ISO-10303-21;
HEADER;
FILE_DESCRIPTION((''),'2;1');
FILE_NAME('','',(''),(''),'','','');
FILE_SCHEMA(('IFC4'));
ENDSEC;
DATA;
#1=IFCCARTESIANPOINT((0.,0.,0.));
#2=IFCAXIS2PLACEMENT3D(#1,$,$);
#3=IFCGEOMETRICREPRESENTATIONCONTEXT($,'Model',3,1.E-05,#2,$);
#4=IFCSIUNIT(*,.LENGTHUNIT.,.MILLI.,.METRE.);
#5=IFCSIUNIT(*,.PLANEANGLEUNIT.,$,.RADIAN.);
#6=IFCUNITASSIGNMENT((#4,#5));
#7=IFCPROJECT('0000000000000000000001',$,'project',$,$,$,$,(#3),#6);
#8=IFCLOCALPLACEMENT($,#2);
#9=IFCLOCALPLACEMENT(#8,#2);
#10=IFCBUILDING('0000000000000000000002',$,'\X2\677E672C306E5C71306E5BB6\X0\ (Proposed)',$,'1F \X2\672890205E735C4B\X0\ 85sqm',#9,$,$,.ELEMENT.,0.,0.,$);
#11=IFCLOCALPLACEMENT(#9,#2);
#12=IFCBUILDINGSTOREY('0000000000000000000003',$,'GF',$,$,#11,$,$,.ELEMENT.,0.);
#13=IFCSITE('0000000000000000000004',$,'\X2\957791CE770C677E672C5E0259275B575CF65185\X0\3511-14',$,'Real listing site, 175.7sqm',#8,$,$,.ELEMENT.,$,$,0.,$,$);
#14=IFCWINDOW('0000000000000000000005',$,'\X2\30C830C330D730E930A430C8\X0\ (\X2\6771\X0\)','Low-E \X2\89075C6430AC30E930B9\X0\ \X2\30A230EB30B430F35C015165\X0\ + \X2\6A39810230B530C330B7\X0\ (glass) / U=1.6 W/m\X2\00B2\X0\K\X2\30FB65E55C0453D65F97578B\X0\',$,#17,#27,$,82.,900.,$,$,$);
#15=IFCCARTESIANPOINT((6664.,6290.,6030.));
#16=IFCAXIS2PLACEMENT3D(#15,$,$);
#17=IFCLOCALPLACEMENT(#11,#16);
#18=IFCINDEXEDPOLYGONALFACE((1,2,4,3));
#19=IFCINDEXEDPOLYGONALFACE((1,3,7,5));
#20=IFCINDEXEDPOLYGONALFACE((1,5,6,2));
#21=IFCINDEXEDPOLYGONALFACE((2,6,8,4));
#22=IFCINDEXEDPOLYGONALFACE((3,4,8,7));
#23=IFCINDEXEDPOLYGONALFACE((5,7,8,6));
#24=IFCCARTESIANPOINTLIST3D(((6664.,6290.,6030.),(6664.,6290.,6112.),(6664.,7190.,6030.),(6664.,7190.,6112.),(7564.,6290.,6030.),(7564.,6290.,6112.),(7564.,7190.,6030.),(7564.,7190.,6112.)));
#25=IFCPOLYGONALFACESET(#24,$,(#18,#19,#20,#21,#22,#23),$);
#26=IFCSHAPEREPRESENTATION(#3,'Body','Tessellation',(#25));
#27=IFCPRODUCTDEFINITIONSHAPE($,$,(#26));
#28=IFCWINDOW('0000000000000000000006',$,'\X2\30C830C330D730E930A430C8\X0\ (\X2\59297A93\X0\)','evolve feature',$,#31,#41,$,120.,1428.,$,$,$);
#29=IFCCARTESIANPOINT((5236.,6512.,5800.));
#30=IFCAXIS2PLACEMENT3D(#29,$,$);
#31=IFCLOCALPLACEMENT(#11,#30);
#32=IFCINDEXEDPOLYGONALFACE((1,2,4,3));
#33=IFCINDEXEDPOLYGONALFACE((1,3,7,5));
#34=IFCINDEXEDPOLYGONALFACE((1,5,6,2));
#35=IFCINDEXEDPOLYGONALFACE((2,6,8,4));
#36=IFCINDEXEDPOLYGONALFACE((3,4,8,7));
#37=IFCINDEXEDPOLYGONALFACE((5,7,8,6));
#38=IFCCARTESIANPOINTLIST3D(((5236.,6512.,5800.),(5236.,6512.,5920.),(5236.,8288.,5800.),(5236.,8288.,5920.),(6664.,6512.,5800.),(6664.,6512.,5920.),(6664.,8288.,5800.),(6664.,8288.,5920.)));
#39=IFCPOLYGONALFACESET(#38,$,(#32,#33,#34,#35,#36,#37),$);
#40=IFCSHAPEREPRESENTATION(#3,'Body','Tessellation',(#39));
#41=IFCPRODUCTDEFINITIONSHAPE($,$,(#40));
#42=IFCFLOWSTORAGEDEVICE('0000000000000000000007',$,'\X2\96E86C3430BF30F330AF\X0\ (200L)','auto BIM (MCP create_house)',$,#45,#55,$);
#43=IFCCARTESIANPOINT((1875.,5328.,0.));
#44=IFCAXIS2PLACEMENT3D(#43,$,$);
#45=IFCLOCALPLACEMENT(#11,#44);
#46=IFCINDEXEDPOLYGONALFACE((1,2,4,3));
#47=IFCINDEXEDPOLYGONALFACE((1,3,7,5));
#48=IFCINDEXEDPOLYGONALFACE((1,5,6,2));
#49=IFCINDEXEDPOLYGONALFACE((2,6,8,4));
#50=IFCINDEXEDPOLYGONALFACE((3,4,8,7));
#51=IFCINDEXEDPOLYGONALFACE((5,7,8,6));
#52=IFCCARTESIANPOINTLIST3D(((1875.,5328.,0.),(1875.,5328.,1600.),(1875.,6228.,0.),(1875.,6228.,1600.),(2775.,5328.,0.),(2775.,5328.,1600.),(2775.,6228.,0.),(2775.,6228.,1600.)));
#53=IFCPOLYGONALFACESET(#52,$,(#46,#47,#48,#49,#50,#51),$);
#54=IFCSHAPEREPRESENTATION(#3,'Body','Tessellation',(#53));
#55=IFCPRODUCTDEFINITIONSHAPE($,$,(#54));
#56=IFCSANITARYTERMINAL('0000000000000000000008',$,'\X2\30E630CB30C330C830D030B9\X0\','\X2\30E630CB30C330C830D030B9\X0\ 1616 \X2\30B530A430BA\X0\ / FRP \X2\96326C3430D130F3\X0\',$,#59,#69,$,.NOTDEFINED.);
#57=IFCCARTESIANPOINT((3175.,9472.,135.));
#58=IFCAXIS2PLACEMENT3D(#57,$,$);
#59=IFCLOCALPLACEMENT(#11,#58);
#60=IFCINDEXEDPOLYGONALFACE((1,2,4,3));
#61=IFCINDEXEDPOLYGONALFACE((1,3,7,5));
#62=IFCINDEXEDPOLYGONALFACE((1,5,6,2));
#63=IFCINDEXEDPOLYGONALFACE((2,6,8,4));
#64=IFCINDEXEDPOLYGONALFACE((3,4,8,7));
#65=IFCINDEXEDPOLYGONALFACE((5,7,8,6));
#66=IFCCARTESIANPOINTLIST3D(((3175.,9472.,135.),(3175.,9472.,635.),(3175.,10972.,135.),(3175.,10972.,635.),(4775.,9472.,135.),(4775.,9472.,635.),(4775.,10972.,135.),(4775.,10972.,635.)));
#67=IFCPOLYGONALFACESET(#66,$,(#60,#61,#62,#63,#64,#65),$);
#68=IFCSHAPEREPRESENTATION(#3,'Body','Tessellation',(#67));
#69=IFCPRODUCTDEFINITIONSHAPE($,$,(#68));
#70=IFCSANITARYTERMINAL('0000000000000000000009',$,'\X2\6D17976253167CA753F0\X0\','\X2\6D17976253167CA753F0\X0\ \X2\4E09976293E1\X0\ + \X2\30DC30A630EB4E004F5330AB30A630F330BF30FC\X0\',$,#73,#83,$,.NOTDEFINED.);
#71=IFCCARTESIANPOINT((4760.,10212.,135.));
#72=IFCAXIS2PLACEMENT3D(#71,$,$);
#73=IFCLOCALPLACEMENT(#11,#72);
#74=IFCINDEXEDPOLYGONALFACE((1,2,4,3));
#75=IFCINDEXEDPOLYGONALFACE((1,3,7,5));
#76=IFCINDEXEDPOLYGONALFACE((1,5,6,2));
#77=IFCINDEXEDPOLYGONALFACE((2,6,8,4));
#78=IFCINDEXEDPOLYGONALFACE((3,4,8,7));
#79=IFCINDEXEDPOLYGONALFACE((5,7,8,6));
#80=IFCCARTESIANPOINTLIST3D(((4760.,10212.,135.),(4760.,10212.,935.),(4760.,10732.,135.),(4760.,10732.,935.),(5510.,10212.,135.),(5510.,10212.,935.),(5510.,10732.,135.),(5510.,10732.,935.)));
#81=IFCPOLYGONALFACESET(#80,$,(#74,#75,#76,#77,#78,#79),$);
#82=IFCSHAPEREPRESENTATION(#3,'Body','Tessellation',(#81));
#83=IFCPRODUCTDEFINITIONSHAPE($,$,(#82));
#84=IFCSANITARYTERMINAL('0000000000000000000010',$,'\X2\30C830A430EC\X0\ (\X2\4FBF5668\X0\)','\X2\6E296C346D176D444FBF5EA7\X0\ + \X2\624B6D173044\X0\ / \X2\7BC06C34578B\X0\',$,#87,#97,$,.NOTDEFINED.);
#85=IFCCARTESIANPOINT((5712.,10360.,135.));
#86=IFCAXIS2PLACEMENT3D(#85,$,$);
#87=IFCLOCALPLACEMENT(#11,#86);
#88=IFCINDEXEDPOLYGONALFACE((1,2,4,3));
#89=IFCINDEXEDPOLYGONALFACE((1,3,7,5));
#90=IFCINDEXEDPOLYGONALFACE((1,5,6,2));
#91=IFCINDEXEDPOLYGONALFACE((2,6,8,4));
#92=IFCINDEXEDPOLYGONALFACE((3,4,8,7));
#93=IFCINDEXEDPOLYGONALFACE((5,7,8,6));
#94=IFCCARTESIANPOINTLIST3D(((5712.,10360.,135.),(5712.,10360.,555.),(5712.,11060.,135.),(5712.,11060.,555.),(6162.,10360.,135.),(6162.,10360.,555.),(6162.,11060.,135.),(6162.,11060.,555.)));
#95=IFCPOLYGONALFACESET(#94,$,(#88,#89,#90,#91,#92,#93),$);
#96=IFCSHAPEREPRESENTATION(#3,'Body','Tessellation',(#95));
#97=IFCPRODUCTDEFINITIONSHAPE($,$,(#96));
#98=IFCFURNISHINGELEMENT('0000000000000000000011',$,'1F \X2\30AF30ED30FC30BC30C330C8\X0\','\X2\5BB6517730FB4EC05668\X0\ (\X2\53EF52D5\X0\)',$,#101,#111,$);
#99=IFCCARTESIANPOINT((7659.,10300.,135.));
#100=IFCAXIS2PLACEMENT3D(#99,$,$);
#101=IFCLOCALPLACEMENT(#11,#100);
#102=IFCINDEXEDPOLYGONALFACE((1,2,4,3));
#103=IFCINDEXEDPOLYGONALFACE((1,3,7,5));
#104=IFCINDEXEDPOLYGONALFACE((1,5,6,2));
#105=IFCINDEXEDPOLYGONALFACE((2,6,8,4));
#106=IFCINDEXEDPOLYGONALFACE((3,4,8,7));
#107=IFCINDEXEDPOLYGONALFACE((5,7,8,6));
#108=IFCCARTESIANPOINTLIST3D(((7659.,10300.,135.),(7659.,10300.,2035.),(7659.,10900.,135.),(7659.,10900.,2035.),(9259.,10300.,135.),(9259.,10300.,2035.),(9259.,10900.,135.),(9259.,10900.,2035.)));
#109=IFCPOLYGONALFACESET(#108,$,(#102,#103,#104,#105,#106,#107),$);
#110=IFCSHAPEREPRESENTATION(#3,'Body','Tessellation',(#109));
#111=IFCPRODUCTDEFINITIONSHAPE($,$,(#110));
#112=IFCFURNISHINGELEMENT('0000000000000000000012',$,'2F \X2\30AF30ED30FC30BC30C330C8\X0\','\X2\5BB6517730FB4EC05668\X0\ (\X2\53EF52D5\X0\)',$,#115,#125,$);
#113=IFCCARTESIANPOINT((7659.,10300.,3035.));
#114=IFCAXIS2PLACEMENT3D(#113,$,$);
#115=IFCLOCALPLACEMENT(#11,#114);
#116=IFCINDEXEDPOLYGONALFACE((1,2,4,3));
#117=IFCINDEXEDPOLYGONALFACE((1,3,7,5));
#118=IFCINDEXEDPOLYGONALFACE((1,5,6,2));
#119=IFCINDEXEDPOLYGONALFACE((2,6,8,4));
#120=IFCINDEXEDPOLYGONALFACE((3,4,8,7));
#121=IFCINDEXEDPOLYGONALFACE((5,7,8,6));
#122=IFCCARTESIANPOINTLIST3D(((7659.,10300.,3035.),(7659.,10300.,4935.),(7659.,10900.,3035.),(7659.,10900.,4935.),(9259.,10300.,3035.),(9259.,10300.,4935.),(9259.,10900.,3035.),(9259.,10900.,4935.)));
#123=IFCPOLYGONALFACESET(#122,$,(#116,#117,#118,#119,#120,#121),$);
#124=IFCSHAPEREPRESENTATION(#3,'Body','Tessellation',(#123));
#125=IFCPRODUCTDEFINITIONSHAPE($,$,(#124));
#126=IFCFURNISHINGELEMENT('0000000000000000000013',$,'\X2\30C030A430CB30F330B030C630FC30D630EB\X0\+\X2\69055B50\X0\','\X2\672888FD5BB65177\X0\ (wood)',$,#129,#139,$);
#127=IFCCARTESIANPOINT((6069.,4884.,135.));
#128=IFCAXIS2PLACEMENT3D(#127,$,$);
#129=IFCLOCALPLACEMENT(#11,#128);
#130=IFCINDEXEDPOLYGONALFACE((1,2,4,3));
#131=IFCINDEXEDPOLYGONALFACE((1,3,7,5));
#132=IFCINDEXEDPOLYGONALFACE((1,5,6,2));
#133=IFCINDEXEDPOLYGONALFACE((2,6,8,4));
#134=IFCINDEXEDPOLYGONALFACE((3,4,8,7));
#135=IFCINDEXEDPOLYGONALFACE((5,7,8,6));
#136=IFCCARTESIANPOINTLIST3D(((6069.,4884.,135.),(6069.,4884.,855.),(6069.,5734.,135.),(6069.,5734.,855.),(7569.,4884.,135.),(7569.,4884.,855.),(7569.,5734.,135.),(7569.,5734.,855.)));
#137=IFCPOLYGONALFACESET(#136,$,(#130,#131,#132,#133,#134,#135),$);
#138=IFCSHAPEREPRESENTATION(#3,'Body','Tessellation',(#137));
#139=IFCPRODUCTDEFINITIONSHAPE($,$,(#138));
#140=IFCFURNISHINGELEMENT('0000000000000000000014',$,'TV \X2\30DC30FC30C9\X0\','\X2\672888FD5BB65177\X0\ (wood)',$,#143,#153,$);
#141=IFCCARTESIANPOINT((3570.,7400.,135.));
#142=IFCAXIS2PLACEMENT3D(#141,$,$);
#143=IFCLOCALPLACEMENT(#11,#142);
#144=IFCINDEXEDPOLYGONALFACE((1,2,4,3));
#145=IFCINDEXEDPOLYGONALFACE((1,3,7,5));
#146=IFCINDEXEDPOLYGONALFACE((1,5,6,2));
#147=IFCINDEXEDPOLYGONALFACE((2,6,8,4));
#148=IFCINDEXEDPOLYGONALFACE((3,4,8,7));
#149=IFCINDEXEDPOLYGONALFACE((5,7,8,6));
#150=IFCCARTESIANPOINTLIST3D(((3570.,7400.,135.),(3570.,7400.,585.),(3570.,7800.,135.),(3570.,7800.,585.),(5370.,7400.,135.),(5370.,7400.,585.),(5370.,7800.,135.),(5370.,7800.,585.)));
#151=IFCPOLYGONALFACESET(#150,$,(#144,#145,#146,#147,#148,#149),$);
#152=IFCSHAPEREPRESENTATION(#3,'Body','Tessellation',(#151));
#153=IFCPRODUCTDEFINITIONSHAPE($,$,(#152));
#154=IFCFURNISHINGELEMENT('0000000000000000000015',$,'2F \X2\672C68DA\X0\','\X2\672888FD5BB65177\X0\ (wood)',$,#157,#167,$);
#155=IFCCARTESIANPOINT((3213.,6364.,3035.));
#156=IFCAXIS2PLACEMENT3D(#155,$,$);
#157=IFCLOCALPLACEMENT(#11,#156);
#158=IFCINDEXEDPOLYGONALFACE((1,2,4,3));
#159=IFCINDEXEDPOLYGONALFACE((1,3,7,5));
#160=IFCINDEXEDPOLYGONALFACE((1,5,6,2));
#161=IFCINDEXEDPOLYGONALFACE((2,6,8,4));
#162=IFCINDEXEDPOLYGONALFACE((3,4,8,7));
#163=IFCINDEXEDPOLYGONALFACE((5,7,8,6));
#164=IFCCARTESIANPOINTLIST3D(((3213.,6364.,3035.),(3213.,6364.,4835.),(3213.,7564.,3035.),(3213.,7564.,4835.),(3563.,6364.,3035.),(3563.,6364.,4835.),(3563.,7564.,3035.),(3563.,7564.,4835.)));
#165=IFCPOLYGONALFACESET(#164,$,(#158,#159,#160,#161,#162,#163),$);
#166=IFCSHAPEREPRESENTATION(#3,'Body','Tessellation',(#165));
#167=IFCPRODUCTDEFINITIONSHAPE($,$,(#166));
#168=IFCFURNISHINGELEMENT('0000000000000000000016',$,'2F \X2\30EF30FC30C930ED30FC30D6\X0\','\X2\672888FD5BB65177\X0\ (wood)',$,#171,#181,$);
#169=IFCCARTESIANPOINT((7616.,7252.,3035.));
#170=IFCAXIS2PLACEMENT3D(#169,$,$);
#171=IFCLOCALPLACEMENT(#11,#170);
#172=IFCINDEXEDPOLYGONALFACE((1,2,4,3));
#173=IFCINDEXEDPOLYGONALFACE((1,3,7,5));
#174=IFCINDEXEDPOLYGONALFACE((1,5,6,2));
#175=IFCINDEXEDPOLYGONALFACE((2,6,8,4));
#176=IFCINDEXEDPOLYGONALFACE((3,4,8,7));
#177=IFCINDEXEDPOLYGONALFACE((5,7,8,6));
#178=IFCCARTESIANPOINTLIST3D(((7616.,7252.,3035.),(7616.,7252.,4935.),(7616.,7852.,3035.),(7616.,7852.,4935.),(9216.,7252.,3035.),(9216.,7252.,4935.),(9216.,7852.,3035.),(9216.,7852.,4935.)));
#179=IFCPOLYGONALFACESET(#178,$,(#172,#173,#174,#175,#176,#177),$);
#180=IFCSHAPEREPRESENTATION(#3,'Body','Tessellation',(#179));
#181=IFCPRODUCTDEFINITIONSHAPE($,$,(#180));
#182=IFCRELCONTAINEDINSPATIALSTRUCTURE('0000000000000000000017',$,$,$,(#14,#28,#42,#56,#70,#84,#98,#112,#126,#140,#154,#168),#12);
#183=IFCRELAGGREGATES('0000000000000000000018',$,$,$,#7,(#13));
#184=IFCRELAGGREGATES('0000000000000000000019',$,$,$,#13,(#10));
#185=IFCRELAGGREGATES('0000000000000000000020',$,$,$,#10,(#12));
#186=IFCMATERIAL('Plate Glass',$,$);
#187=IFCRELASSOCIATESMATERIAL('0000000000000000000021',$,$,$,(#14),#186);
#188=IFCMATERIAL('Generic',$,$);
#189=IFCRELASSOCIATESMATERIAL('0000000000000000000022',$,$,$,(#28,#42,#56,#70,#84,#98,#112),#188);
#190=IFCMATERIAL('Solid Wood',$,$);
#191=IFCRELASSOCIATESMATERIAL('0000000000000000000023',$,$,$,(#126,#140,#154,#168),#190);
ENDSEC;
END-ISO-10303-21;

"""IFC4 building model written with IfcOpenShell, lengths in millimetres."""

from ifc_helpers import new_model, si_unit, frame, frame_2d, origin, place, context, project, spatial, rectangle, extrude, material, element, save


model = new_model("IFC4")

# Units and contexts
model_context = context("Model", 3, precision=1e-05, world=origin())
ifc_project = project(units=[si_unit("LENGTHUNIT", "METRE", prefix="MILLI"), si_unit("PLANEANGLEUNIT", "RADIAN")], contexts=[model_context])

# Site, building, storey
site_placement = place(None, origin())
site = spatial("IfcSite", under=ifc_project, at=site_placement, Name="長野県松本市大字島内3511-14", ObjectType="Real listing site, 175.7sqm", CompositionType="ELEMENT", RefElevation=0.0)
building_placement = place(site_placement, origin())
building = spatial("IfcBuilding", under=site, at=building_placement, Name="松本の山の家 (Proposed)", ObjectType="1F 木造平屋 85sqm", CompositionType="ELEMENT", ElevationOfRefHeight=0.0, ElevationOfTerrain=0.0)
storey_placement = place(building_placement, origin())
storey = spatial("IfcBuildingStorey", under=building, at=storey_placement, Name="GF", CompositionType="ELEMENT", Elevation=0.0)

# Shared definitions
ifc_material_1 = material(Name="Solid Wood")
ifc_material_2 = material(Name="Plate Glass")

# Windows
window_1_placement = place(storey_placement, frame((6664.0, 6290.0, 6030.0)))
element("IfcWindow", 1, at=window_1_placement, inside=storey, material=ifc_material_2, Name="トップライト (東)", Description="Low-E 複層ガラス アルゴン封入 + 樹脂サッシ (glass) / U=1.6 W/m²K・日射取得型", OverallHeight=82.0, OverallWidth=900.0, context=model_context, shape_type="SweptSolid", body=[
    extrude(rectangle(XDim=900.0, YDim=900.0, at=frame_2d((450.0, 450.0))), frame((6664.0, 6290.0, 6030.0)), (0.0, 0.0, 1.0), 82.0),
])
ifc_material_3 = material(Name="Generic")
window_2_placement = place(storey_placement, frame((5236.0, 6512.0, 5800.0)))
element("IfcWindow", 2, at=window_2_placement, inside=storey, material=ifc_material_3, Name="トップライト (天窓)", Description="evolve feature", OverallHeight=120.0, OverallWidth=1428.0, context=model_context, shape_type="SweptSolid", body=[
    extrude(rectangle(XDim=1428.0, YDim=1776.0, at=frame_2d((714.0, 888.0))), frame((5236.0, 6512.0, 5800.0)), (0.0, 0.0, 1.0), 120.0),
])

# Flow storage device
flow_storage_device_placement = place(storey_placement, frame((1875.0, 5328.0, 0.0)))
element("IfcFlowStorageDevice", 3, at=flow_storage_device_placement, inside=storey, material=ifc_material_3, Name="雨水タンク (200L)", Description="auto BIM (MCP create_house)", context=model_context, shape_type="SweptSolid", body=[
    extrude(rectangle(XDim=900.0, YDim=900.0, at=frame_2d((450.0, 450.0))), frame((1875.0, 5328.0, 0.0)), (0.0, 0.0, 1.0), 1600.0),
])

# Sanitary terminals
sanitary_terminal_1_placement = place(storey_placement, frame((3175.0, 9472.0, 135.0)))
element("IfcSanitaryTerminal", 4, at=sanitary_terminal_1_placement, inside=storey, material=ifc_material_3, Name="ユニットバス", Description="ユニットバス 1616 サイズ / FRP 防水パン", PredefinedType="NOTDEFINED", context=model_context, shape_type="SweptSolid", body=[
    extrude(rectangle(XDim=1600.0, YDim=1500.0, at=frame_2d((800.0, 750.0))), frame((3175.0, 9472.0, 135.0)), (0.0, 0.0, 1.0), 500.0),
])
sanitary_terminal_2_placement = place(storey_placement, frame((4760.0, 10212.0, 135.0)))
element("IfcSanitaryTerminal", 5, at=sanitary_terminal_2_placement, inside=storey, material=ifc_material_3, Name="洗面化粧台", Description="洗面化粧台 三面鏡 + ボウル一体カウンター", PredefinedType="NOTDEFINED", context=model_context, shape_type="SweptSolid", body=[
    extrude(rectangle(XDim=750.0, YDim=520.0, at=frame_2d((375.0, 260.0))), frame((4760.0, 10212.0, 135.0)), (0.0, 0.0, 1.0), 800.0),
])
sanitary_terminal_3_placement = place(storey_placement, frame((5712.0, 10360.0, 135.0)))
element("IfcSanitaryTerminal", 6, at=sanitary_terminal_3_placement, inside=storey, material=ifc_material_3, Name="トイレ (便器)", Description="温水洗浄便座 + 手洗い / 節水型", PredefinedType="NOTDEFINED", context=model_context, shape_type="SweptSolid", body=[
    extrude(rectangle(XDim=450.0, YDim=700.0, at=frame_2d((225.0, 350.0))), frame((5712.0, 10360.0, 135.0)), (0.0, 0.0, 1.0), 420.0),
])

# Furnishing elements
furnishing_1_placement = place(storey_placement, frame((7659.0, 10300.0, 135.0)))
element("IfcFurnishingElement", 7, at=furnishing_1_placement, inside=storey, material=ifc_material_3, Name="1F クローゼット", Description="家具・什器 (可動)", context=model_context, shape_type="SweptSolid", body=[
    extrude(rectangle(XDim=1600.0, YDim=600.0, at=frame_2d((800.0, 300.0))), frame((7659.0, 10300.0, 135.0)), (0.0, 0.0, 1.0), 1900.0),
])
furnishing_2_placement = place(storey_placement, frame((7659.0, 10300.0, 3035.0)))
element("IfcFurnishingElement", 8, at=furnishing_2_placement, inside=storey, material=ifc_material_3, Name="2F クローゼット", Description="家具・什器 (可動)", context=model_context, shape_type="SweptSolid", body=[
    extrude(rectangle(XDim=1600.0, YDim=600.0, at=frame_2d((800.0, 300.0))), frame((7659.0, 10300.0, 3035.0)), (0.0, 0.0, 1.0), 1900.0),
])
furnishing_3_placement = place(storey_placement, frame((6069.0, 4884.0, 135.0)))
element("IfcFurnishingElement", 9, at=furnishing_3_placement, inside=storey, material=ifc_material_1, Name="ダイニングテーブル+椅子", Description="木製家具 (wood)", context=model_context, shape_type="SweptSolid", body=[
    extrude(rectangle(XDim=1500.0, YDim=850.0, at=frame_2d((750.0, 425.0))), frame((6069.0, 4884.0, 135.0)), (0.0, 0.0, 1.0), 720.0),
])
furnishing_4_placement = place(storey_placement, frame((3570.0, 7400.0, 135.0)))
element("IfcFurnishingElement", 10, at=furnishing_4_placement, inside=storey, material=ifc_material_1, Name="TV ボード", Description="木製家具 (wood)", context=model_context, shape_type="SweptSolid", body=[
    extrude(rectangle(XDim=1800.0, YDim=400.0, at=frame_2d((900.0, 200.0))), frame((3570.0, 7400.0, 135.0)), (0.0, 0.0, 1.0), 450.0),
])
furnishing_5_placement = place(storey_placement, frame((3213.0, 6364.0, 3035.0)))
element("IfcFurnishingElement", 11, at=furnishing_5_placement, inside=storey, material=ifc_material_1, Name="2F 本棚", Description="木製家具 (wood)", context=model_context, shape_type="SweptSolid", body=[
    extrude(rectangle(XDim=350.0, YDim=1200.0, at=frame_2d((175.0, 600.0))), frame((3213.0, 6364.0, 3035.0)), (0.0, 0.0, 1.0), 1800.0),
])
furnishing_6_placement = place(storey_placement, frame((7616.0, 7252.0, 3035.0)))
element("IfcFurnishingElement", 12, at=furnishing_6_placement, inside=storey, material=ifc_material_1, Name="2F ワードローブ", Description="木製家具 (wood)", context=model_context, shape_type="SweptSolid", body=[
    extrude(rectangle(XDim=1600.0, YDim=600.0, at=frame_2d((800.0, 300.0))), frame((7616.0, 7252.0, 3035.0)), (0.0, 0.0, 1.0), 1900.0),
])

save(model, "model.ifc")
